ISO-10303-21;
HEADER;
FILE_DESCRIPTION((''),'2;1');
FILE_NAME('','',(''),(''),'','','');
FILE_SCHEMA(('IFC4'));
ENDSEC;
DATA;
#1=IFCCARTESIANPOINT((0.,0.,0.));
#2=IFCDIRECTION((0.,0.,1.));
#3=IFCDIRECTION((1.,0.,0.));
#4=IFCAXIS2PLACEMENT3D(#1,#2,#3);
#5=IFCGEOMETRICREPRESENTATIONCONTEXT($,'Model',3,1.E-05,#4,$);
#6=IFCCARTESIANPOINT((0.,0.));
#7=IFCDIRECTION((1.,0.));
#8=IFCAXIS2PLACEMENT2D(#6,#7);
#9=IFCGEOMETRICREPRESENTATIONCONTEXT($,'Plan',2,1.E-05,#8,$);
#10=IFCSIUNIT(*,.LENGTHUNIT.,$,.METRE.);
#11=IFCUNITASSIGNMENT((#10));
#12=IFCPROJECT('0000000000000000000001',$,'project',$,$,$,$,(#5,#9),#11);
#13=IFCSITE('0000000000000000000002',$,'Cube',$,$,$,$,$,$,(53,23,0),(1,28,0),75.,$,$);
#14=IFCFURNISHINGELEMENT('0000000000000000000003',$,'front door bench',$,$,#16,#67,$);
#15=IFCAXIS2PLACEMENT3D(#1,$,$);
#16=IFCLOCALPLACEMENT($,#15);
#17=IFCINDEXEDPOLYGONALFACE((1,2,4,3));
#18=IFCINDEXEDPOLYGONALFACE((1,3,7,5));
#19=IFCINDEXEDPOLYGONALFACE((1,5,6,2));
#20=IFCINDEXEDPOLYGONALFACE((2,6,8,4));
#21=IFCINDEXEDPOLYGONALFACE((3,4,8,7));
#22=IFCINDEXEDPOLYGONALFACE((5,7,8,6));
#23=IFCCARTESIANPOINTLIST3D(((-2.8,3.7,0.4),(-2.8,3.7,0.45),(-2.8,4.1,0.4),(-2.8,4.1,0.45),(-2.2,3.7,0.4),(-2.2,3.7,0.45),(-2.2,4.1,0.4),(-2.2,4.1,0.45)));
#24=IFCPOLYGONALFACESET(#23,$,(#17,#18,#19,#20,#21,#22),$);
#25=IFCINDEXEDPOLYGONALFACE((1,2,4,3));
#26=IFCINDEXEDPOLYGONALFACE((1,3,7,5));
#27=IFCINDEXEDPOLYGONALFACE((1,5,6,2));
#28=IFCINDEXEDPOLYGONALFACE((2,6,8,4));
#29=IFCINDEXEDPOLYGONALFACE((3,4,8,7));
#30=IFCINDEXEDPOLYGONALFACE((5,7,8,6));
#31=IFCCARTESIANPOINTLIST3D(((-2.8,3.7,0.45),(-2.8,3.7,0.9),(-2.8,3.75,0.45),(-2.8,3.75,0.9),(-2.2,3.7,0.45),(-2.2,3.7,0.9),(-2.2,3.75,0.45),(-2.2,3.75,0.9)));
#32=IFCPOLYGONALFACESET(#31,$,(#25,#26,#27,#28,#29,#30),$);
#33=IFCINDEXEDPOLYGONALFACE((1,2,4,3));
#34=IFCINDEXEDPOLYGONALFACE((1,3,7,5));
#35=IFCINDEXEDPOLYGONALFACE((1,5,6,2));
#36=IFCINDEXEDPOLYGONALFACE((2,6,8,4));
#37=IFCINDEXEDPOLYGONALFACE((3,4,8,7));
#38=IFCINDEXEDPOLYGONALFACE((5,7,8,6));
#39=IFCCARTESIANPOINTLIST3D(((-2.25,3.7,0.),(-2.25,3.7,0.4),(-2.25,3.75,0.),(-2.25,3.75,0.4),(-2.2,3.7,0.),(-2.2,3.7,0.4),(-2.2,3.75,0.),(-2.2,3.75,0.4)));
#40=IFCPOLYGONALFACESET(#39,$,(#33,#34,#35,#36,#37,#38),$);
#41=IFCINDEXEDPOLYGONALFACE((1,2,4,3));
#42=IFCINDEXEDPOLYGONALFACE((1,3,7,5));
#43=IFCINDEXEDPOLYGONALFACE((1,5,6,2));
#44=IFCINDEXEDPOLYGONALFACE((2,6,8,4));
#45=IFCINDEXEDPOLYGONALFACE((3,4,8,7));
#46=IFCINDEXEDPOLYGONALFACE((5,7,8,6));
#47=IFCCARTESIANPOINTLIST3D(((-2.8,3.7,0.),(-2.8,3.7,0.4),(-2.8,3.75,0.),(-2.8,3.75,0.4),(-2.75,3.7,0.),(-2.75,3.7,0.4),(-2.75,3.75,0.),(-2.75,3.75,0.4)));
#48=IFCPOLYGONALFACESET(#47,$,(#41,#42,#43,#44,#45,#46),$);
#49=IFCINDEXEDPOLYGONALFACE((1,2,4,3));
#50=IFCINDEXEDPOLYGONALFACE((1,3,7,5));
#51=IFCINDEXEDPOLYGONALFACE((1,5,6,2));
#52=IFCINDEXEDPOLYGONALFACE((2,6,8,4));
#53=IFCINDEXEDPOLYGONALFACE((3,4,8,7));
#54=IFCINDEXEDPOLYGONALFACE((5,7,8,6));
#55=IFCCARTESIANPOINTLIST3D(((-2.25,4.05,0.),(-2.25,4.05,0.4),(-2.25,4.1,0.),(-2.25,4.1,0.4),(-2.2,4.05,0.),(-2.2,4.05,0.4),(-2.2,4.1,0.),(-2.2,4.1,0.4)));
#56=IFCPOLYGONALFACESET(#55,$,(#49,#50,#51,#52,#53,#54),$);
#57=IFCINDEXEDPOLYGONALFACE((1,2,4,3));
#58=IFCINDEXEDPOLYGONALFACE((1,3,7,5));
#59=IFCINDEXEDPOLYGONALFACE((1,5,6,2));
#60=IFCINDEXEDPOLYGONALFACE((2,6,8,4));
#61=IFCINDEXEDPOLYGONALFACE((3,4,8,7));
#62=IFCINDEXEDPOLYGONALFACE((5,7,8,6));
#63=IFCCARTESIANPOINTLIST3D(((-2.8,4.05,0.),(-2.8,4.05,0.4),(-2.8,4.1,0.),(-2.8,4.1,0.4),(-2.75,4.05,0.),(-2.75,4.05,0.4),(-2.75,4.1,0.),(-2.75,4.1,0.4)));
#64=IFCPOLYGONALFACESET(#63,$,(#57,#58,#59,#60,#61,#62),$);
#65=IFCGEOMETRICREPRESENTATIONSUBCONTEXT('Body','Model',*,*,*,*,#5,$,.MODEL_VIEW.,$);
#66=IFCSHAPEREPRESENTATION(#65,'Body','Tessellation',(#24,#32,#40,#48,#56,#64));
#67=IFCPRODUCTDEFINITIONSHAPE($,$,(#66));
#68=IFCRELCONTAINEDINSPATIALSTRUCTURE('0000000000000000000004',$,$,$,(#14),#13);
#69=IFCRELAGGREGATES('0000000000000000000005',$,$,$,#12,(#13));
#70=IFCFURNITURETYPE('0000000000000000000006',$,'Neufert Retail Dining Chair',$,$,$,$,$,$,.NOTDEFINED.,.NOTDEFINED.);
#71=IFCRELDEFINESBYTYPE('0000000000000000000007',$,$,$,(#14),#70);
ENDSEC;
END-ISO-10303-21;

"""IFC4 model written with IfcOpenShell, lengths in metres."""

from ifc_helpers import new_model, entity, si_unit, frame, origin_with_axes, origin_2d_with_axis, place, context, subcontext, project, spatial, line, indexed_curve, outline, extrude, shape, source, transform, mapped, type_object, type_shapes, element, save


model = new_model("IFC4")

# Units and contexts
model_context = context("Model", 3, precision=1e-05, world=origin_with_axes())
plan_context = context("Plan", 2, precision=1e-05, world=origin_2d_with_axis())
body_context_1 = subcontext(model_context, "Body", "Model", "MODEL_VIEW")
body_context_2 = subcontext(plan_context, "Body", "Plan", "PLAN_VIEW")
ifc_project = project(units=[si_unit("LENGTHUNIT", "METRE")], contexts=[model_context, plan_context])

# Site
site = spatial("IfcSite", under=ifc_project, Name="Cube", RefLatitude=(53, 23, 0), RefLongitude=(1, 28, 0), RefElevation=75.0)

# Furnishing element
furniture_type = type_object("IfcFurnitureType", Name="Neufert Retail Dining Chair", AssemblyPlace="NOTDEFINED", PredefinedType="NOTDEFINED")
shared_shape_1 = source(origin_with_axes(), body_context_1, "Body", "SweptSolid", [
    extrude(outline(indexed_curve([(-0.3, 0.0), (0.3, 0.0), (0.3, -0.4), (-0.3, -0.4)], segments=[line(1, 2, 3, 4, 1)])), frame((0.0, 0.0, 0.45), z_axis=(0.0, 0.0, 1.0), x_axis=(1.0, 0.0, 0.0)), (0.0, 0.0, -1.0), 0.05),
    extrude(outline(indexed_curve([(-0.3, 0.0), (0.3, 0.0), (0.3, -0.05), (-0.3, -0.05)], segments=[line(1, 2, 3, 4, 1)])), frame((0.0, 0.0, 0.9), z_axis=(0.0, 0.0, 1.0), x_axis=(1.0, 0.0, 0.0)), (0.0, 0.0, -1.0), 0.45),
    extrude(outline(indexed_curve([(-0.3, 0.0), (-0.25, 0.0), (-0.25, -0.05), (-0.3, -0.05)], segments=[line(1, 2, 3, 4, 1)])), origin_with_axes(), (0.0, 0.0, 1.0), 0.4),
    extrude(outline(indexed_curve([(0.3, 0.0), (0.25, 0.0), (0.25, -0.05), (0.3, -0.05)], segments=[line(1, 2, 3, 4, 1)])), origin_with_axes(), (0.0, 0.0, 1.0), 0.4),
    extrude(outline(indexed_curve([(-0.3, -0.4), (-0.25, -0.4), (-0.25, -0.35), (-0.3, -0.35)], segments=[line(1, 2, 3, 4, 1)])), origin_with_axes(), (0.0, 0.0, 1.0), 0.4),
    extrude(outline(indexed_curve([(0.3, -0.4), (0.25, -0.4), (0.25, -0.35), (0.3, -0.35)], segments=[line(1, 2, 3, 4, 1)])), origin_with_axes(), (0.0, 0.0, 1.0), 0.4),
])
shared_shape_2 = source(origin_with_axes(), body_context_2, "Body", "Curve2D", [
    entity("IfcIndexedPolyCurve", entity("IfcCartesianPointList2D", [[-0.3, -0.4], [0.3, -0.4]])),
    entity("IfcIndexedPolyCurve", entity("IfcCartesianPointList2D", [[-0.3, -0.4], [-0.3, -0.3], [-0.2121, -0.0879], [0.0, 0.0], [0.2121, -0.0879], [0.3, -0.3], [0.3, -0.4]]), [entity("IfcLineIndex", [1, 2]), entity("IfcArcIndex", [2, 3, 4]), entity("IfcArcIndex", [4, 5, 6]), entity("IfcLineIndex", [6, 7])]),
    entity("IfcIndexedPolyCurve", entity("IfcCartesianPointList2D", [[-0.26, -0.4], [-0.26, -0.3], [-0.1838, -0.1162], [0.0, -0.04], [0.1838, -0.1162], [0.26, -0.3], [0.26, -0.4]]), [entity("IfcLineIndex", [1, 2]), entity("IfcArcIndex", [2, 3, 4]), entity("IfcArcIndex", [4, 5, 6]), entity("IfcLineIndex", [6, 7])]),
])
type_shapes(furniture_type, [shared_shape_1, shared_shape_2])
furnishing_placement = place(None, frame((-2.5, 3.7, 0.0), z_axis=(0.0, 0.0, 1.0), x_axis=(-1.0, 0.0, 0.0)))
element("IfcFurnishingElement", 1, at=furnishing_placement, inside=site, type_object=furniture_type, Name="front door bench", shapes=[
    shape(body_context_1, "Body", "MappedRepresentation", [mapped(shared_shape_1, transform((0.0, 0.0, 0.0), x_axis=(1.0, 0.0, 0.0), y_axis=(0.0, 1.0, 0.0), z_axis=(0.0, 0.0, 1.0), scale=1.0))]),
    shape(body_context_2, "Body", "MappedRepresentation", [mapped(shared_shape_2, transform((0.0, 0.0, 0.0), x_axis=(1.0, 0.0, 0.0), y_axis=(0.0, 1.0, 0.0), z_axis=(0.0, 0.0, 1.0), scale=1.0))]),
])

save(model, "model.ifc")
